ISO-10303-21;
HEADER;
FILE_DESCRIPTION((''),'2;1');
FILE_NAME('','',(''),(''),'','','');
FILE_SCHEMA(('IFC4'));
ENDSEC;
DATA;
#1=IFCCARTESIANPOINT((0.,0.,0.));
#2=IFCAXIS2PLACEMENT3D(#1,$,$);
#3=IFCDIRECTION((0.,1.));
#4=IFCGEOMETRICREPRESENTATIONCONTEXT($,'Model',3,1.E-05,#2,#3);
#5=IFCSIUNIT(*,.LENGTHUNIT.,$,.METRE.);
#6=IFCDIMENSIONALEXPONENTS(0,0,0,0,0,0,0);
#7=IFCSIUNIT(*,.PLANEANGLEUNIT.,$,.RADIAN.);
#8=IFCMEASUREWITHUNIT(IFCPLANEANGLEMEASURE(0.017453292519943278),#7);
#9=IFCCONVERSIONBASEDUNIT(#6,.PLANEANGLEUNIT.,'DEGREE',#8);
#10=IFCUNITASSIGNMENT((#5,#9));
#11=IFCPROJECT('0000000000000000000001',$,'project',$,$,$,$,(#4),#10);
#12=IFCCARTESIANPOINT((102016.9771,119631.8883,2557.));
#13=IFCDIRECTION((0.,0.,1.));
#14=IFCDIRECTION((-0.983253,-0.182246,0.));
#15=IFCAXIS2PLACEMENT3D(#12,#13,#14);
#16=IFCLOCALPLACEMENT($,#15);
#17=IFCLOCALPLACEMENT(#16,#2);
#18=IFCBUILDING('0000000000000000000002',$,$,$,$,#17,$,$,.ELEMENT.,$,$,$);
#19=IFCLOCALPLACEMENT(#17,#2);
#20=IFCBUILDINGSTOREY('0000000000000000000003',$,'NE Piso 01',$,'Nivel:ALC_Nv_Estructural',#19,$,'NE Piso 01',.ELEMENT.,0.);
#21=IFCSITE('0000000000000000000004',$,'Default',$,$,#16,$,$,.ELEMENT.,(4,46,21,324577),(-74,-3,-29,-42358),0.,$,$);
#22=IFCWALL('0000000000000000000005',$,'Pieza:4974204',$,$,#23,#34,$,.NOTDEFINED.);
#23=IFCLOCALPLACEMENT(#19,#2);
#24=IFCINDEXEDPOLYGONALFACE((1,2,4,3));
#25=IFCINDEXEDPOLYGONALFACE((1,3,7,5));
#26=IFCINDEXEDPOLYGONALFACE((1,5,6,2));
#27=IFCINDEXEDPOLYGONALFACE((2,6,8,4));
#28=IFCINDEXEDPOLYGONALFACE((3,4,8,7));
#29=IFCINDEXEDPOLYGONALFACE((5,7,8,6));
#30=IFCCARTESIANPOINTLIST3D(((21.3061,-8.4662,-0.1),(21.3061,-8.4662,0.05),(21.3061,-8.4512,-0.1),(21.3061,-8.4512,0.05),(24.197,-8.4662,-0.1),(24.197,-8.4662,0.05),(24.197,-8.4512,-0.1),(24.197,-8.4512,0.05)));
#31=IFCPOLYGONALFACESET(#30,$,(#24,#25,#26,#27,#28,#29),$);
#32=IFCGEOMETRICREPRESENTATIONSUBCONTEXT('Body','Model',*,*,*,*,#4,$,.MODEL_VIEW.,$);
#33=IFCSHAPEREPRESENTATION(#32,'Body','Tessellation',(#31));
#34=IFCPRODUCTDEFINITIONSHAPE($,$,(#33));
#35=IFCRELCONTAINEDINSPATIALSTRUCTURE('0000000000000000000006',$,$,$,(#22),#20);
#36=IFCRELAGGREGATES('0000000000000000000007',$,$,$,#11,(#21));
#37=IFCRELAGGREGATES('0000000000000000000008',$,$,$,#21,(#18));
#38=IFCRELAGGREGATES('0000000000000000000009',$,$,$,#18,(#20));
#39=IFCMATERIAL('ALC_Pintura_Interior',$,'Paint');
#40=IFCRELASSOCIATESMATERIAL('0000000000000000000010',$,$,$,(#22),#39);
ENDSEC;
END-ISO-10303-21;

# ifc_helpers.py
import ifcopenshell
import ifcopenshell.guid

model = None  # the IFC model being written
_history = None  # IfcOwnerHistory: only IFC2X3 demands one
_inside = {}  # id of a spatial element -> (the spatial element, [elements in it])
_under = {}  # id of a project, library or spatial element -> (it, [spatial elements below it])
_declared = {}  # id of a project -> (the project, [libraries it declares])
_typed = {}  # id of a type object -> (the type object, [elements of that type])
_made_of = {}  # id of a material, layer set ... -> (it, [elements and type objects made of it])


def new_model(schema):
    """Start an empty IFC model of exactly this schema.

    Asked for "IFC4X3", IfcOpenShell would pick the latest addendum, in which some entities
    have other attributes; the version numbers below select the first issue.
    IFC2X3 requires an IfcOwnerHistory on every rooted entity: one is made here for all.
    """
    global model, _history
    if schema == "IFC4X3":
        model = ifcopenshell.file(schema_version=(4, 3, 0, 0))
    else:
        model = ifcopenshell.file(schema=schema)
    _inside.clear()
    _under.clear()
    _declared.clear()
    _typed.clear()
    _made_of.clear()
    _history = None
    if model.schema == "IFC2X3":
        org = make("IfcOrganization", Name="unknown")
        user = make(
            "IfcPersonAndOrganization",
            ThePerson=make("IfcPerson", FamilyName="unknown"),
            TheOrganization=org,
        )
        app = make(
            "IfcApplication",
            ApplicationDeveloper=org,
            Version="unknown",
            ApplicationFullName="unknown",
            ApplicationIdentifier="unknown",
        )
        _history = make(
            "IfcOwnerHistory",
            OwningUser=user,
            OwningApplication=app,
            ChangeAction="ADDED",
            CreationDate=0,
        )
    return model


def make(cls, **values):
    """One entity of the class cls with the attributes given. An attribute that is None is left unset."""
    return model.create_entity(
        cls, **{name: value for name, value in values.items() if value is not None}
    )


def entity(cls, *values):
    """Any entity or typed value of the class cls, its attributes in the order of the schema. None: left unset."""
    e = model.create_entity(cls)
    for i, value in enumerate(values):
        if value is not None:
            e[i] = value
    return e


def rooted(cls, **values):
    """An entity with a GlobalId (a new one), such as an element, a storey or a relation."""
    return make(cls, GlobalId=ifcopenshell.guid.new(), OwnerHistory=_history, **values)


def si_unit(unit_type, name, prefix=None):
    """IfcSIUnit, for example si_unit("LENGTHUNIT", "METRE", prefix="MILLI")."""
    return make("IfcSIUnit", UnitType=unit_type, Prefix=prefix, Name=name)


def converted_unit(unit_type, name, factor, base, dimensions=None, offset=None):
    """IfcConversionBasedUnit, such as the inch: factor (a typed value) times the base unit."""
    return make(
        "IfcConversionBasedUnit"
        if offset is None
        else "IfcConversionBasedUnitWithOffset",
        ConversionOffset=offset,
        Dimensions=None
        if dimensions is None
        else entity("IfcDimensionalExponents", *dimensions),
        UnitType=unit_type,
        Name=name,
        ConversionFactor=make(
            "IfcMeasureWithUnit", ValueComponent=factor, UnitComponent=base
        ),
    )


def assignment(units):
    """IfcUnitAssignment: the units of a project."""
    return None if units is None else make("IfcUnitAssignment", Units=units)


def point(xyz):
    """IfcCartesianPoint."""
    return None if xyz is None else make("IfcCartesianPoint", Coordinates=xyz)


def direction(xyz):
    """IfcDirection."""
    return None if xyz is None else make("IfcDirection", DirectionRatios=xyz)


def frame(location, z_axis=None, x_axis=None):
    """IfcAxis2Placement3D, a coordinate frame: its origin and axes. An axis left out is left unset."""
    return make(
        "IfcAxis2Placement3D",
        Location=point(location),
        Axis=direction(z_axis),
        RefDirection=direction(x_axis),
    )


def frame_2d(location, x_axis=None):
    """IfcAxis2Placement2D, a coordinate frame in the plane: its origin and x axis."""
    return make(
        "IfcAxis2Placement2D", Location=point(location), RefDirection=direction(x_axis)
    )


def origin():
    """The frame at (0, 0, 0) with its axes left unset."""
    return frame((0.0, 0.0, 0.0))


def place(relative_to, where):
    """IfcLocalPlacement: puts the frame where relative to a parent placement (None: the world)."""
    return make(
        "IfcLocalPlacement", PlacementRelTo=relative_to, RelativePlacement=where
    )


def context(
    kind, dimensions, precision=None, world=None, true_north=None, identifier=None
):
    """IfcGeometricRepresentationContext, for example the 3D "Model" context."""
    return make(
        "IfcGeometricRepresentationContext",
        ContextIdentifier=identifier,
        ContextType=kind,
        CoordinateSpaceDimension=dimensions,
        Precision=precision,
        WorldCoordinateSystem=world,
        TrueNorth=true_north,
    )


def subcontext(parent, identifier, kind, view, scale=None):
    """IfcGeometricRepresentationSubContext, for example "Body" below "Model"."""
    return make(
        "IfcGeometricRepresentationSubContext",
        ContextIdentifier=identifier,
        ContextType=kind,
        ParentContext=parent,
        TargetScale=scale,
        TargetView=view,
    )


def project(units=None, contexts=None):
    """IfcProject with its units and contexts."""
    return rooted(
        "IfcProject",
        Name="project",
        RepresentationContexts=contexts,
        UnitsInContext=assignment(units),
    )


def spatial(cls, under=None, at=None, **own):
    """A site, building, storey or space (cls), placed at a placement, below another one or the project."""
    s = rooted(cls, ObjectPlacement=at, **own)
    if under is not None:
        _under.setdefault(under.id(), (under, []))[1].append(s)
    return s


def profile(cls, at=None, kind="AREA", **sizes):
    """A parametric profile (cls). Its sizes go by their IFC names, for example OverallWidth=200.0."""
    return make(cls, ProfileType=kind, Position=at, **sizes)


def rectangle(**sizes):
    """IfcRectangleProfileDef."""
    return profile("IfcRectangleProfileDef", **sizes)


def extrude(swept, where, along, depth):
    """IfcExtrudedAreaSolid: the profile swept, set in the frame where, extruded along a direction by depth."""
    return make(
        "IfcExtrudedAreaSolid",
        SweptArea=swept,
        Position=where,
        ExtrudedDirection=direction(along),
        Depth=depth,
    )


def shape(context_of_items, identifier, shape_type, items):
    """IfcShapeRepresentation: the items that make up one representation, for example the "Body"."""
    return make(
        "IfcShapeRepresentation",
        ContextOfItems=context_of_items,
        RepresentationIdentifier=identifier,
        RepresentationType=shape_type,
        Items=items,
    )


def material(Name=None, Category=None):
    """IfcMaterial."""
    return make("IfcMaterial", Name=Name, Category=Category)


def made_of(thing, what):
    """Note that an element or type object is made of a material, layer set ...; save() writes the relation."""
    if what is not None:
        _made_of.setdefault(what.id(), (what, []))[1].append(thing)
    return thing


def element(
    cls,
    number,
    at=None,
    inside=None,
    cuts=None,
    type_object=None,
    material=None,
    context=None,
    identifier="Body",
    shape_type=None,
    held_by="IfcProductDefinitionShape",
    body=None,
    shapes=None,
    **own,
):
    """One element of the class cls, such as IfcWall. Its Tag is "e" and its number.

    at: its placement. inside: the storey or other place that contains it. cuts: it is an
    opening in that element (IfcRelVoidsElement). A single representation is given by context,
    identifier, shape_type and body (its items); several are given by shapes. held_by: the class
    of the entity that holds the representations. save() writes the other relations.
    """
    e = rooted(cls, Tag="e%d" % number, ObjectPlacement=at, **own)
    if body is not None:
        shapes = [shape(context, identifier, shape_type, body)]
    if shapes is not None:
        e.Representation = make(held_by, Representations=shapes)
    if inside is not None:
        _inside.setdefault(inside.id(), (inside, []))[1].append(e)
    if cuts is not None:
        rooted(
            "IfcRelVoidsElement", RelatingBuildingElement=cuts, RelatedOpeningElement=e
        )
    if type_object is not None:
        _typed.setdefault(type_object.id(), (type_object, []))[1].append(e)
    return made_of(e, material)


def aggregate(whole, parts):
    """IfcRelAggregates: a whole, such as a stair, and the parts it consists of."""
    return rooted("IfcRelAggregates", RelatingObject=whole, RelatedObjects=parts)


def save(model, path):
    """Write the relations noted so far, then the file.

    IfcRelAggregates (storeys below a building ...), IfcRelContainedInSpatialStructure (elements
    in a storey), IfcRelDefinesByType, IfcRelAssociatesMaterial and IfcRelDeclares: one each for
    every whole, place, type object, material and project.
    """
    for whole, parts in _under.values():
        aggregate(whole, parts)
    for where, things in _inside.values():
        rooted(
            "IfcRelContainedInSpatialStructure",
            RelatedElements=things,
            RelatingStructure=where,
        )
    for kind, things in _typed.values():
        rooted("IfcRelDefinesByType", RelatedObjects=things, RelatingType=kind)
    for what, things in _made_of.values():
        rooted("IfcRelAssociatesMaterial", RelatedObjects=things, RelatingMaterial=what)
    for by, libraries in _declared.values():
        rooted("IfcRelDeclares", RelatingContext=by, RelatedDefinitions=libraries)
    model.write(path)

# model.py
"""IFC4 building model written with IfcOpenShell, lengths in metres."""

from ifc_helpers import new_model, entity, si_unit, converted_unit, direction, frame, frame_2d, origin, place, context, subcontext, project, spatial, rectangle, extrude, material, element, save


model = new_model("IFC4")

# Units and contexts
model_context = context("Model", 3, precision=1e-05, world=origin(), true_north=direction((0.0, 1.0)))
body_context = subcontext(model_context, "Body", "Model", "MODEL_VIEW")
ifc_project = project(units=[si_unit("LENGTHUNIT", "METRE"), converted_unit("PLANEANGLEUNIT", "DEGREE", entity("IfcPlaneAngleMeasure", 0.017453292519943278), si_unit("PLANEANGLEUNIT", "RADIAN"), dimensions=[0, 0, 0, 0, 0, 0, 0])], contexts=[model_context])

# Site, building, storey
site_placement = place(None, frame((102016.9771, 119631.8883, 2557.0), z_axis=(0.0, 0.0, 1.0), x_axis=(-0.983253, -0.182246, 0.0)))
site = spatial("IfcSite", under=ifc_project, at=site_placement, Name="Default", CompositionType="ELEMENT", RefLatitude=(4, 46, 21, 324577), RefLongitude=(-74, -3, -29, -42358), RefElevation=0.0)
building_placement = place(site_placement, origin())
building = spatial("IfcBuilding", under=site, at=building_placement, CompositionType="ELEMENT")
storey_placement = place(building_placement, origin())
storey = spatial("IfcBuildingStorey", under=building, at=storey_placement, Name="NE Piso 01", ObjectType="Nivel:ALC_Nv_Estructural", LongName="NE Piso 01", CompositionType="ELEMENT", Elevation=0.0)

# Wall
ifc_material_1 = material(Name="ALC_Pintura_Interior", Category="Paint")
wall_1_placement = place(storey_placement, frame((0.0, 0.0, -0.1)))
element("IfcWall", 1, at=wall_1_placement, inside=storey, material=ifc_material_1, Name="Pieza:4974204", PredefinedType="NOTDEFINED", context=body_context, shape_type="SweptSolid", body=[
    extrude(rectangle(XDim=0.015, YDim=2.8909, at=frame_2d((0.0, 0.0), x_axis=(1.0, 0.0))), frame((22.7516, -8.4587, 0.0), z_axis=(0.0, 0.0, 1.0), x_axis=(0.0, -1.0, 0.0)), (0.0, 0.0, 1.0), 0.15),
])

save(model, "model.ifc")
